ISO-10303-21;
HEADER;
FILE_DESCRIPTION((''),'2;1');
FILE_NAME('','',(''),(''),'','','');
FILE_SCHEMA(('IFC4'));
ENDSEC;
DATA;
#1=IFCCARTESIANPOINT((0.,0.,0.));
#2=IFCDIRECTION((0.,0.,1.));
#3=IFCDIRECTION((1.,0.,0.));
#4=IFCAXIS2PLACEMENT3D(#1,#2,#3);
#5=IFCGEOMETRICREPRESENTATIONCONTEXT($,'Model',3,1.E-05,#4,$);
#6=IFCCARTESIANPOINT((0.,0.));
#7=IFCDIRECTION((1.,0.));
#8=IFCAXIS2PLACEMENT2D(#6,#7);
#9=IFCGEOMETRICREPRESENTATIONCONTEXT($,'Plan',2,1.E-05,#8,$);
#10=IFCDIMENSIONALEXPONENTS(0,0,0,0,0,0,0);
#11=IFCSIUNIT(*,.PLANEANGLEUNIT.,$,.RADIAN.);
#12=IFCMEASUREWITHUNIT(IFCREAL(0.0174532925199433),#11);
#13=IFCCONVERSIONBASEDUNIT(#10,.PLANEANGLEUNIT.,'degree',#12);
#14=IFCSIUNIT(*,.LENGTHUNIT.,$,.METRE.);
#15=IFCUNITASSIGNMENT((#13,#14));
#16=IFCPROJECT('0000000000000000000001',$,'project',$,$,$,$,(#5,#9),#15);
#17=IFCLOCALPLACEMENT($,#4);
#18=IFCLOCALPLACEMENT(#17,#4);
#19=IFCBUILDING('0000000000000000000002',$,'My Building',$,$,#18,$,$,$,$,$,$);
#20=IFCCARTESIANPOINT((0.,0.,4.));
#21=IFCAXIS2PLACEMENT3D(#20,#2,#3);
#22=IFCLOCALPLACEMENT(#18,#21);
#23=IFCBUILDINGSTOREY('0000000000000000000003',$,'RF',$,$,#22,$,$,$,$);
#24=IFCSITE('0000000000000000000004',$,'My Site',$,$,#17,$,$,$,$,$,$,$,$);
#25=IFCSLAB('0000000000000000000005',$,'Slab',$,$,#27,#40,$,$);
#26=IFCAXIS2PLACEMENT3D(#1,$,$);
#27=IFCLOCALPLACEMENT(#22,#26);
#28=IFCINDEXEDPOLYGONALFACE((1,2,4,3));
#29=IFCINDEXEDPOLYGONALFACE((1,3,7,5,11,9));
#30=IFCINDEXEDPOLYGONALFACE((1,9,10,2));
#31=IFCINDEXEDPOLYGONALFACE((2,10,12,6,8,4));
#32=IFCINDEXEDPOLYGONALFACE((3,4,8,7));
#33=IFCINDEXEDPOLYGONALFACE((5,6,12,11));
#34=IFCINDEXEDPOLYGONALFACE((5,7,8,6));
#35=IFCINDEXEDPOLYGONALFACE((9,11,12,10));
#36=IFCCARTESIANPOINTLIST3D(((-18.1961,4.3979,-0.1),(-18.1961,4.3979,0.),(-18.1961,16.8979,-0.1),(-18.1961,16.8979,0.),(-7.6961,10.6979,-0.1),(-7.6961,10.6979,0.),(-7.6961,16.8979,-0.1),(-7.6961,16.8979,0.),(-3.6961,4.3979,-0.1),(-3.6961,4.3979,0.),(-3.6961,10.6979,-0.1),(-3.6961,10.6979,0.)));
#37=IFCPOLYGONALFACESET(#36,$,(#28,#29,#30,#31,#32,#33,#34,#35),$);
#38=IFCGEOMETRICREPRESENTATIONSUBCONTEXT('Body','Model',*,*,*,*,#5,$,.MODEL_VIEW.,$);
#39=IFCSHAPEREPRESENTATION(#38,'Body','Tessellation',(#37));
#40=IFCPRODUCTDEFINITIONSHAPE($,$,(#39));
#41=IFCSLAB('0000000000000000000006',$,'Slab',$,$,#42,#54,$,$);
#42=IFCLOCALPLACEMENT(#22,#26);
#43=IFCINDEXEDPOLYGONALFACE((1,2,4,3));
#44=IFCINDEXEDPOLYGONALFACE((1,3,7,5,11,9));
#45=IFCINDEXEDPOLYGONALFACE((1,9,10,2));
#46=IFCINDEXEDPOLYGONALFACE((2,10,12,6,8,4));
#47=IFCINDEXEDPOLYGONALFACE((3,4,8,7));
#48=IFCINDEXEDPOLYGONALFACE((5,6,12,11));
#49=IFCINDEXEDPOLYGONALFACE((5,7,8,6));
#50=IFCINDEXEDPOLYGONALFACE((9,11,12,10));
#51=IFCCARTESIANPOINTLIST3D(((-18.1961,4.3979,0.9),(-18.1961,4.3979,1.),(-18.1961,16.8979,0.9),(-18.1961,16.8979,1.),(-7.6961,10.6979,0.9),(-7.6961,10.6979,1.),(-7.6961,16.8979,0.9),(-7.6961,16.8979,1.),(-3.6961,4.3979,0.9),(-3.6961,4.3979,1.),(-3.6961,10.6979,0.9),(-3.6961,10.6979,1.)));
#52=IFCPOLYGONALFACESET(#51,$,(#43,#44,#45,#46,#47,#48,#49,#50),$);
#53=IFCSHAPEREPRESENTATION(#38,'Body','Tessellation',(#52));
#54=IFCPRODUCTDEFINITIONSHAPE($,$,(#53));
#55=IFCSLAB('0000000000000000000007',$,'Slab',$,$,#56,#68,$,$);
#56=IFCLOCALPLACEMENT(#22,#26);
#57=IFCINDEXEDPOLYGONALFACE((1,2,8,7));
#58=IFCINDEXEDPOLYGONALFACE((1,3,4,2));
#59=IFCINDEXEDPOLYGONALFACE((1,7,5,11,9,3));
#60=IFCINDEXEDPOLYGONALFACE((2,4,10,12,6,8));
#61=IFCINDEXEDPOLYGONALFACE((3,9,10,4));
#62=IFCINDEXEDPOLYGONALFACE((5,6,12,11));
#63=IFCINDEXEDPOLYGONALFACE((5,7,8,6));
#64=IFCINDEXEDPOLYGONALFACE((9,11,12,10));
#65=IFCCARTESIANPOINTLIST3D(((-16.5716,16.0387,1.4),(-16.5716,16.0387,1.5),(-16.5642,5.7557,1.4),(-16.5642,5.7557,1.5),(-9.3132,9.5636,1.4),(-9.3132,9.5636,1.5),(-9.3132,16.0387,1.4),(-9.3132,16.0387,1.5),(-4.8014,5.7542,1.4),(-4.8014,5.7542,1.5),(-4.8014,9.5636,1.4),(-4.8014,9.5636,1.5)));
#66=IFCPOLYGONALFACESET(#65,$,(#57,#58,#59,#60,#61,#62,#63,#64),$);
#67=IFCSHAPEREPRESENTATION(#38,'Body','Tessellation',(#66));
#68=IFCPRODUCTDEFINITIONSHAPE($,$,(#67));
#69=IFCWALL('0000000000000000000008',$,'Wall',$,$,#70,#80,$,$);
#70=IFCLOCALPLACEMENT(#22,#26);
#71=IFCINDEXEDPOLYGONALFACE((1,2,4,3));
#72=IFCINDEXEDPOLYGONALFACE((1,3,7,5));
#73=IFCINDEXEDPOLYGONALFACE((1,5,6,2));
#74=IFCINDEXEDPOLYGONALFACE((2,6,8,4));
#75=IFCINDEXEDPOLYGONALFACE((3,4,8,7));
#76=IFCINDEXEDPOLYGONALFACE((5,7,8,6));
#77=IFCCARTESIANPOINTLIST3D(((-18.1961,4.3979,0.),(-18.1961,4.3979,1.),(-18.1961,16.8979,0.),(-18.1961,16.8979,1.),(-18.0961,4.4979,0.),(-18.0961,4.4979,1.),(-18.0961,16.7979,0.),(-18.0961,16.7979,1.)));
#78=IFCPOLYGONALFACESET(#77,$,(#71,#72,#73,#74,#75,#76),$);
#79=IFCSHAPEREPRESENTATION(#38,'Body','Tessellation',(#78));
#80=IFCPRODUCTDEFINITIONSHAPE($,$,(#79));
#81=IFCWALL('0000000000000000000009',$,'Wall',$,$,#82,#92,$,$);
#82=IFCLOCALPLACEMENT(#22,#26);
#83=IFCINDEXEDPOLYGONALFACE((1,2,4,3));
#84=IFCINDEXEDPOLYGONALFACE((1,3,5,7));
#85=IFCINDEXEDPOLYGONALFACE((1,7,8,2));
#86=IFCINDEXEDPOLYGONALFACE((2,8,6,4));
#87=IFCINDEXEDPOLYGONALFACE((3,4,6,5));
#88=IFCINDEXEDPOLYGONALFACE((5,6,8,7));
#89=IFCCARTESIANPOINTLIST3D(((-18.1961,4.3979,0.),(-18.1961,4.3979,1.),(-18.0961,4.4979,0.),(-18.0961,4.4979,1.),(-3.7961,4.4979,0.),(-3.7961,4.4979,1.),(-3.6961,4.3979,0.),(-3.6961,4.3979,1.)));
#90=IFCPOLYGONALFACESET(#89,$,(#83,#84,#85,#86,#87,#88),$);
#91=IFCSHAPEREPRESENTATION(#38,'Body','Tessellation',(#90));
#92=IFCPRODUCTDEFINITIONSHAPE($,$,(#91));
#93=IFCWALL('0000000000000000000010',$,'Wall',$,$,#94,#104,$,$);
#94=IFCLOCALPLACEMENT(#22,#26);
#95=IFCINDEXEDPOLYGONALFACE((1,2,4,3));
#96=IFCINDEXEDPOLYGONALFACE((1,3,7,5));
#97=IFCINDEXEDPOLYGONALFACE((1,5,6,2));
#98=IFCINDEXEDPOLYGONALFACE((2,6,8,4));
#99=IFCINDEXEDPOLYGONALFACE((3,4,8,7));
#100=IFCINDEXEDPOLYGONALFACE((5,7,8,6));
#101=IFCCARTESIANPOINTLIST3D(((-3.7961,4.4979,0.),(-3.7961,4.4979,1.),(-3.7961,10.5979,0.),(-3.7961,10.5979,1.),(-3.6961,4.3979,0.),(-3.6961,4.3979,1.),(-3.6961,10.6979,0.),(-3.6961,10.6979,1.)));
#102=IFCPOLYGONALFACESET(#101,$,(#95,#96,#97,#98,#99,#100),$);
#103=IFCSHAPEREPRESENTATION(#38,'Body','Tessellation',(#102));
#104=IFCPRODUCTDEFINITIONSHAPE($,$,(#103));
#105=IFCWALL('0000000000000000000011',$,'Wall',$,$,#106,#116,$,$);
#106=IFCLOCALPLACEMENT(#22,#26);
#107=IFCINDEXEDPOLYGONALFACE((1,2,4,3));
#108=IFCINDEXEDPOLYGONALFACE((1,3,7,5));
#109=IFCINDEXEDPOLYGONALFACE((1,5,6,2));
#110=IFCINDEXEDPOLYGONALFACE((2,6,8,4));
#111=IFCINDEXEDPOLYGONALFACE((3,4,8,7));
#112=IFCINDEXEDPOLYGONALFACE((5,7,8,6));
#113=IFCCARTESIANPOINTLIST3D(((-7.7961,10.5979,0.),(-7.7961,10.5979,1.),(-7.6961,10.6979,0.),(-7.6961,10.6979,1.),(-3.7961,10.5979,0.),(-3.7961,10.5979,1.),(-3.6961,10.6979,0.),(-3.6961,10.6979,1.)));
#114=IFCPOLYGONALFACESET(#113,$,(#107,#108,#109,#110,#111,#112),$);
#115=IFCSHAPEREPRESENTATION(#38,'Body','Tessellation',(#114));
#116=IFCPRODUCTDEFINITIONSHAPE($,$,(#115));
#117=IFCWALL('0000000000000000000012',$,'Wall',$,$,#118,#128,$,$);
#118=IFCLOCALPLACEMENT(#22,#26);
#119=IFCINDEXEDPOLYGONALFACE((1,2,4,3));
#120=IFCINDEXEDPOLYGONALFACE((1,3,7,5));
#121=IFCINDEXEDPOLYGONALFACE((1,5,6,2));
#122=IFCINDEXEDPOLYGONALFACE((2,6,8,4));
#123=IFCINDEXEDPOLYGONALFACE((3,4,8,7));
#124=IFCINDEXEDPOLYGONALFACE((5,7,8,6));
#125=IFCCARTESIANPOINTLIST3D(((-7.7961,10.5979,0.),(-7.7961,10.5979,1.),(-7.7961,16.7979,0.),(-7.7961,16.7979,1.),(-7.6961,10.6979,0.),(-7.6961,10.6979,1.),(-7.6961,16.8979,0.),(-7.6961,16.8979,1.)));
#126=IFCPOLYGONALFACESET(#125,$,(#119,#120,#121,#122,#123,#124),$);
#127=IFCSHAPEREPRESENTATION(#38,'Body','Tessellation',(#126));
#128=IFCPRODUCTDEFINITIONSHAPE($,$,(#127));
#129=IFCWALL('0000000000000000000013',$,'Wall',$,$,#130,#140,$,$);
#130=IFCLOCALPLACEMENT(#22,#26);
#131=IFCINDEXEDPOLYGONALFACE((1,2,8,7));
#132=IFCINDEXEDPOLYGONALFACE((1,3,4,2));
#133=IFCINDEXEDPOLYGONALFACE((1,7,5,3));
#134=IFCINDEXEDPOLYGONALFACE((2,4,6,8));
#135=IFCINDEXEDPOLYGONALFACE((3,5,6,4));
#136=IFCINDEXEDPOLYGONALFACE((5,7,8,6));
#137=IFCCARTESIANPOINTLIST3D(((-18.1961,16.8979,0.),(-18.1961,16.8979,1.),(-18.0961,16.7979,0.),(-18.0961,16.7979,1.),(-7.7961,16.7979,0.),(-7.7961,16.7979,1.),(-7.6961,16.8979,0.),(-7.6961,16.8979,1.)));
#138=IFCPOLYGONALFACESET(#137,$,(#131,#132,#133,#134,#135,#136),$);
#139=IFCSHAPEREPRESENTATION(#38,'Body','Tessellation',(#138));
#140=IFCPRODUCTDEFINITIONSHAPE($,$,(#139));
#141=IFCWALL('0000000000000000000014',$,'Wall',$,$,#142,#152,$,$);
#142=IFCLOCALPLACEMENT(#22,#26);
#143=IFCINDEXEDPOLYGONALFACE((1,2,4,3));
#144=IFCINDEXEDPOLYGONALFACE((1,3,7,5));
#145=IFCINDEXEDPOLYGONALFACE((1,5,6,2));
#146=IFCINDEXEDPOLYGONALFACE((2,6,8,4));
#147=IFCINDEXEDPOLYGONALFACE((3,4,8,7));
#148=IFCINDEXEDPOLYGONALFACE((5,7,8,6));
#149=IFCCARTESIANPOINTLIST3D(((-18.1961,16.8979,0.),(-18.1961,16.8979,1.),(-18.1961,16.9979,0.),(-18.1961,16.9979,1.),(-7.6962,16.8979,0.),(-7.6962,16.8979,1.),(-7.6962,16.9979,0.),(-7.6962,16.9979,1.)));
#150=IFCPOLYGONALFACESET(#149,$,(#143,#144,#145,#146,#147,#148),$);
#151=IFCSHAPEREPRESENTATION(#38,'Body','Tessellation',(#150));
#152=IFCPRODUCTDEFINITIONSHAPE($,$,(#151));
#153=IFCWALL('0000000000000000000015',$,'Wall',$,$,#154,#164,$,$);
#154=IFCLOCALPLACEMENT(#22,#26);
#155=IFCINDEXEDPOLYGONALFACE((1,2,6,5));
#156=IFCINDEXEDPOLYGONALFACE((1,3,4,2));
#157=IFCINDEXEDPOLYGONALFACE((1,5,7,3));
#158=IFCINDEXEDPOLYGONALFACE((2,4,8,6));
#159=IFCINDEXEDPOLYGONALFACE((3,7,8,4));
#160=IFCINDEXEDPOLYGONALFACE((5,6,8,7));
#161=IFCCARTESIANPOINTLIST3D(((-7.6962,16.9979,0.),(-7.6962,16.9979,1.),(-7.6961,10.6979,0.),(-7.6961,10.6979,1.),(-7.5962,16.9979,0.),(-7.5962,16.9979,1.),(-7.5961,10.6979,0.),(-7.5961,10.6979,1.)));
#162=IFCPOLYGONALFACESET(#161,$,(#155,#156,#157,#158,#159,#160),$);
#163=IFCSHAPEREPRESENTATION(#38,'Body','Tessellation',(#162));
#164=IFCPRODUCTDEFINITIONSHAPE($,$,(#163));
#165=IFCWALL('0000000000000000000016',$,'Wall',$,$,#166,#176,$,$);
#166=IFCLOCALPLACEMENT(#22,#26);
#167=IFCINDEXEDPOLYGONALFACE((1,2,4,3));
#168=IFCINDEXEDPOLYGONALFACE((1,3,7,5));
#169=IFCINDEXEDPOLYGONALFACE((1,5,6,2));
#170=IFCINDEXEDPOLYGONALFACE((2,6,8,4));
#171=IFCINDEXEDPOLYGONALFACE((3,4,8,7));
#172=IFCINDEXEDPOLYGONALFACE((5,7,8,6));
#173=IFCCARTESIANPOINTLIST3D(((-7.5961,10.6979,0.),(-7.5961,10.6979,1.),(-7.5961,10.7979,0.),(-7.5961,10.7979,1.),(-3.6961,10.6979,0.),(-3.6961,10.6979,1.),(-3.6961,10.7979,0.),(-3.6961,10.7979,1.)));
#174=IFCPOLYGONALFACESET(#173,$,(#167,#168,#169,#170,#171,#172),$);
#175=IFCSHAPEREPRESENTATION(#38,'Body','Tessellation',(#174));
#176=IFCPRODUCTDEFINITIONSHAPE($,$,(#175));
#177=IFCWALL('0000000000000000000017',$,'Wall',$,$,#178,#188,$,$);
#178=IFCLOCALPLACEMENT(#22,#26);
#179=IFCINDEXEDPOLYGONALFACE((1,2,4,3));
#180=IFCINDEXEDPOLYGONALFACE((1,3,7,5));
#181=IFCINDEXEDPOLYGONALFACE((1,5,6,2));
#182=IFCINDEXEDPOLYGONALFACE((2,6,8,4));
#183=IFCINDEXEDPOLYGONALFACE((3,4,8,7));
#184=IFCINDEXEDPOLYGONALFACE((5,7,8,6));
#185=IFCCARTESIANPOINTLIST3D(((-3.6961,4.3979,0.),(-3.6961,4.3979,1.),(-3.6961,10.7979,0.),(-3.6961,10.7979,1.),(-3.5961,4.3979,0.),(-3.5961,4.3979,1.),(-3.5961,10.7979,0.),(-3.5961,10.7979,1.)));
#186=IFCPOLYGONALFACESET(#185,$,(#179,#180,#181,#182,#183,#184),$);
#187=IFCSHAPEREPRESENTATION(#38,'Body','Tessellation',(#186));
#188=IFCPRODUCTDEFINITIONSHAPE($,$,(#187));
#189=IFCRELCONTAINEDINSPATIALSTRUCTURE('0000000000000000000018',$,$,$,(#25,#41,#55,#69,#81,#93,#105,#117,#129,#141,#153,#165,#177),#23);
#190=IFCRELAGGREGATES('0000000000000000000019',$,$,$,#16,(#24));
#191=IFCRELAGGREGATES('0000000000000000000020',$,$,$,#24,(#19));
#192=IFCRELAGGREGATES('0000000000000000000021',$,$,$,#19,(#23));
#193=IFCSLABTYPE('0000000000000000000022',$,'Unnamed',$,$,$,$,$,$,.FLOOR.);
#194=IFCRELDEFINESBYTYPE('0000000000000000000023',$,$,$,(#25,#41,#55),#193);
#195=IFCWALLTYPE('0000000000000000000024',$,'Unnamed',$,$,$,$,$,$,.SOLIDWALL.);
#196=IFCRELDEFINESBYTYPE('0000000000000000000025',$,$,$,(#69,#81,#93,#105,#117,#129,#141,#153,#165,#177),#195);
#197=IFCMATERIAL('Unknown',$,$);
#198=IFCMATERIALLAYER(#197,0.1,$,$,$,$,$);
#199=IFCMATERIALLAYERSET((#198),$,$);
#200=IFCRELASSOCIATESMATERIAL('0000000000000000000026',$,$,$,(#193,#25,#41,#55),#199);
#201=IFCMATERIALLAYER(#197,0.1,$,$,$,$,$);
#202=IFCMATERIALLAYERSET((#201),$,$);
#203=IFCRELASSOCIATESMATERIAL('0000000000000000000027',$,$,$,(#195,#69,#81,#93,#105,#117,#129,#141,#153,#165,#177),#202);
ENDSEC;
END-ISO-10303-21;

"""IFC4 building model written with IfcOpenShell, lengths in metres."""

from ifc_helpers import new_model, entity, si_unit, converted_unit, frame, origin_with_axes, origin_2d_with_axis, place, context, subcontext, project, spatial, line, indexed_curve, outline, extrude, material, layer, layer_set, layer_usage, type_object, element, save


model = new_model("IFC4")

# Units and contexts
model_context = context("Model", 3, precision=1e-05, world=origin_with_axes())
plan_context = context("Plan", 2, precision=1e-05, world=origin_2d_with_axis())
body_context = subcontext(model_context, "Body", "Model", "MODEL_VIEW")
ifc_project = project(units=[converted_unit("PLANEANGLEUNIT", "degree", entity("IfcReal", 0.0174532925199433), si_unit("PLANEANGLEUNIT", "RADIAN"), dimensions=[0, 0, 0, 0, 0, 0, 0]), si_unit("LENGTHUNIT", "METRE")], contexts=[model_context, plan_context])

# Site, building, storey
site_placement = place(None, origin_with_axes())
site = spatial("IfcSite", under=ifc_project, at=site_placement, Name="My Site")
building_placement = place(site_placement, origin_with_axes())
building = spatial("IfcBuilding", under=site, at=building_placement, Name="My Building")
storey_placement = place(building_placement, frame((0.0, 0.0, 4.0), z_axis=(0.0, 0.0, 1.0), x_axis=(1.0, 0.0, 0.0)))
storey = spatial("IfcBuildingStorey", under=building, at=storey_placement, Name="RF")

# Slabs
ifc_material = material(Name="Unknown")
ifc_layer_1 = layer(ifc_material, 0.1)
ifc_layer_set_1 = layer_set([ifc_layer_1])
ifc_layer_usage_1 = layer_usage(ifc_layer_set_1, "AXIS3", "POSITIVE", -0.1)
slab_type = type_object("IfcSlabType", Name="Unnamed", PredefinedType="FLOOR", material=ifc_layer_set_1)
slab_1_placement = place(storey_placement, frame((-18.1961, 16.8979, 0.0), z_axis=(0.0, 0.0, 1.0), x_axis=(1.0, 0.0, 0.0)))
element("IfcSlab", 1, at=slab_1_placement, inside=storey, type_object=slab_type, material=ifc_layer_usage_1, Name="Slab", context=body_context, shape_type="SweptSolid", body=[
    extrude(outline(indexed_curve([(0.0, 0.0), (10.5, 0.0), (10.5, -6.2), (14.5, -6.2), (14.5, -12.5), (0.0, -12.5), (0.0, 0.0)])), frame((0.0, 0.0, -0.1), z_axis=(0.0, 0.0, 1.0), x_axis=(1.0, 0.0, 0.0)), (0.0, 0.0, 1.0), 0.1),
])
ifc_layer_usage_2 = layer_usage(ifc_layer_set_1, "AXIS3", "POSITIVE", -0.1)
slab_2_placement = place(storey_placement, frame((-18.1961, 16.8979, 1.0), z_axis=(0.0, 0.0, 1.0), x_axis=(1.0, 0.0, 0.0)))
element("IfcSlab", 2, at=slab_2_placement, inside=storey, type_object=slab_type, material=ifc_layer_usage_2, Name="Slab", context=body_context, shape_type="SweptSolid", body=[
    extrude(outline(indexed_curve([(0.0, 0.0), (10.5, 0.0), (10.5, -6.2), (14.5, -6.2), (14.5, -12.5), (0.0, -12.5), (0.0, 0.0)])), frame((0.0, 0.0, -0.1), z_axis=(0.0, 0.0, 1.0), x_axis=(1.0, 0.0, 0.0)), (0.0, 0.0, 1.0), 0.1),
])
ifc_layer_usage_3 = layer_usage(ifc_layer_set_1, "AXIS3", "POSITIVE", -0.1)
slab_3_placement = place(storey_placement, frame((-16.5716, 16.0387, 1.5), z_axis=(0.0, 0.0, 1.0), x_axis=(1.0, 0.0, 0.0)))
element("IfcSlab", 3, at=slab_3_placement, inside=storey, type_object=slab_type, material=ifc_layer_usage_3, Name="Slab", context=body_context, shape_type="SweptSolid", body=[
    extrude(outline(indexed_curve([(0.0, 0.0), (7.2584, 0.0), (7.2584, -6.4751), (11.7702, -6.4751), (11.7702, -10.2844), (0.0074, -10.283), (0.0, 0.0)])), frame((0.0, 0.0, -0.1), z_axis=(0.0, 0.0, 1.0), x_axis=(1.0, 0.0, 0.0)), (0.0, 0.0, 1.0), 0.1),
])

# Walls
ifc_layer_2 = layer(ifc_material, 0.1)
ifc_layer_set_2 = layer_set([ifc_layer_2])
ifc_layer_usage_4 = layer_usage(ifc_layer_set_2, "AXIS2", "POSITIVE", 0.0)
wall_type = type_object("IfcWallType", Name="Unnamed", PredefinedType="SOLIDWALL", material=ifc_layer_set_2)
wall_1_placement = place(storey_placement, frame((-18.1961, 16.8979, 0.0), z_axis=(0.0, 0.0, 1.0), x_axis=(0.0, -1.0, 0.0)))
element("IfcWall", 4, at=wall_1_placement, inside=storey, type_object=wall_type, material=ifc_layer_usage_4, Name="Wall", context=body_context, shape_type="SweptSolid", body=[
    extrude(outline(indexed_curve([(0.0, 0.0), (0.1, 0.1), (12.4, 0.1), (12.5, 0.0)], segments=[line(1, 2, 3, 4, 1)])), origin_with_axes(), (0.0, 0.0, 1.0), 1.0),
])
ifc_layer_usage_5 = layer_usage(ifc_layer_set_2, "AXIS2", "POSITIVE", 0.0)
wall_2_placement = place(storey_placement, frame((-18.1961, 4.3979, 0.0), z_axis=(0.0, 0.0, 1.0), x_axis=(1.0, 0.0, 0.0)))
element("IfcWall", 5, at=wall_2_placement, inside=storey, type_object=wall_type, material=ifc_layer_usage_5, Name="Wall", context=body_context, shape_type="SweptSolid", body=[
    extrude(outline(indexed_curve([(0.0, 0.0), (0.1, 0.1), (14.4, 0.1), (14.5, 0.0)], segments=[line(1, 2, 3, 4, 1)])), origin_with_axes(), (0.0, 0.0, 1.0), 1.0),
])
ifc_layer_usage_6 = layer_usage(ifc_layer_set_2, "AXIS2", "POSITIVE", 0.0)
wall_3_placement = place(storey_placement, frame((-3.6961, 4.3979, 0.0), z_axis=(0.0, 0.0, 1.0), x_axis=(0.0, 1.0, 0.0)))
element("IfcWall", 6, at=wall_3_placement, inside=storey, type_object=wall_type, material=ifc_layer_usage_6, Name="Wall", context=body_context, shape_type="SweptSolid", body=[
    extrude(outline(indexed_curve([(0.0, 0.0), (0.1, 0.1), (6.2, 0.1), (6.3, 0.0)], segments=[line(1, 2, 3, 4, 1)])), origin_with_axes(), (0.0, 0.0, 1.0), 1.0),
])
ifc_layer_usage_7 = layer_usage(ifc_layer_set_2, "AXIS2", "POSITIVE", 0.0)
wall_4_placement = place(storey_placement, frame((-3.6961, 10.6979, 0.0), z_axis=(0.0, 0.0, 1.0), x_axis=(-1.0, 0.0, 0.0)))
element("IfcWall", 7, at=wall_4_placement, inside=storey, type_object=wall_type, material=ifc_layer_usage_7, Name="Wall", context=body_context, shape_type="SweptSolid", body=[
    extrude(outline(indexed_curve([(0.0, 0.0), (0.1, 0.1), (4.1, 0.1), (4.0, 0.0)], segments=[line(1, 2, 3, 4, 1)])), origin_with_axes(), (0.0, 0.0, 1.0), 1.0),
])
ifc_layer_usage_8 = layer_usage(ifc_layer_set_2, "AXIS2", "POSITIVE", 0.0)
wall_5_placement = place(storey_placement, frame((-7.6961, 10.6979, 0.0), z_axis=(0.0, 0.0, 1.0), x_axis=(0.0, 1.0, 0.0)))
element("IfcWall", 8, at=wall_5_placement, inside=storey, type_object=wall_type, material=ifc_layer_usage_8, Name="Wall", context=body_context, shape_type="SweptSolid", body=[
    extrude(outline(indexed_curve([(0.0, 0.0), (-0.1, 0.1), (6.1, 0.1), (6.2, 0.0)], segments=[line(1, 2, 3, 4, 1)])), origin_with_axes(), (0.0, 0.0, 1.0), 1.0),
])
ifc_layer_usage_9 = layer_usage(ifc_layer_set_2, "AXIS2", "POSITIVE", 0.0)
wall_6_placement = place(storey_placement, frame((-7.6961, 16.8979, 0.0), z_axis=(0.0, 0.0, 1.0), x_axis=(-1.0, 0.0, 0.0)))
element("IfcWall", 9, at=wall_6_placement, inside=storey, type_object=wall_type, material=ifc_layer_usage_9, Name="Wall", context=body_context, shape_type="SweptSolid", body=[
    extrude(outline(indexed_curve([(0.0, 0.0), (0.1, 0.1), (10.4, 0.1), (10.5, 0.0)], segments=[line(1, 2, 3, 4, 1)])), origin_with_axes(), (0.0, 0.0, 1.0), 1.0),
])
ifc_layer_usage_10 = layer_usage(ifc_layer_set_2, "AXIS2", "POSITIVE", 0.0)
wall_7_placement = place(storey_placement, frame((-18.1961, 16.8979, 0.0), z_axis=(0.0, 0.0, 1.0), x_axis=(1.0, 0.0, 0.0)))
element("IfcWall", 10, at=wall_7_placement, inside=storey, type_object=wall_type, material=ifc_layer_usage_10, Name="Wall", context=body_context, shape_type="SweptSolid", body=[
    extrude(outline(indexed_curve([(0.0, 0.0), (0.0, 0.1), (10.4999, 0.1), (10.4999, 0.0)], segments=[line(1, 2, 3, 4, 1)])), origin_with_axes(), (0.0, 0.0, 1.0), 1.0),
])
ifc_layer_usage_11 = layer_usage(ifc_layer_set_2, "AXIS2", "POSITIVE", 0.0)
wall_8_placement = place(storey_placement, frame((-7.6962, 16.9979, 0.0), z_axis=(0.0, 0.0, 1.0), x_axis=(0.000012, -1.0, 0.0)))
element("IfcWall", 11, at=wall_8_placement, inside=storey, type_object=wall_type, material=ifc_layer_usage_11, Name="Wall", context=body_context, shape_type="SweptSolid", body=[
    extrude(outline(indexed_curve([(0.0, 0.0), (0.0, 0.1), (6.3, 0.1), (6.3, 0.0)], segments=[line(1, 2, 3, 4, 1)])), origin_with_axes(), (0.0, 0.0, 1.0), 1.0),
])
ifc_layer_usage_12 = layer_usage(ifc_layer_set_2, "AXIS2", "POSITIVE", 0.0)
wall_9_placement = place(storey_placement, frame((-7.5961, 10.6979, 0.0), z_axis=(0.0, 0.0, 1.0), x_axis=(1.0, 0.0, 0.0)))
element("IfcWall", 12, at=wall_9_placement, inside=storey, type_object=wall_type, material=ifc_layer_usage_12, Name="Wall", context=body_context, shape_type="SweptSolid", body=[
    extrude(outline(indexed_curve([(0.0, 0.0), (0.0, 0.1), (3.9, 0.1), (3.9, 0.0)], segments=[line(1, 2, 3, 4, 1)])), origin_with_axes(), (0.0, 0.0, 1.0), 1.0),
])
ifc_layer_usage_13 = layer_usage(ifc_layer_set_2, "AXIS2", "POSITIVE", 0.0)
wall_10_placement = place(storey_placement, frame((-3.6961, 10.7979, 0.0), z_axis=(0.0, 0.0, 1.0), x_axis=(0.0, -1.0, 0.0)))
element("IfcWall", 13, at=wall_10_placement, inside=storey, type_object=wall_type, material=ifc_layer_usage_13, Name="Wall", context=body_context, shape_type="SweptSolid", body=[
    extrude(outline(indexed_curve([(0.0, 0.0), (0.0, 0.1), (6.4, 0.1), (6.4, 0.0)], segments=[line(1, 2, 3, 4, 1)])), origin_with_axes(), (0.0, 0.0, 1.0), 1.0),
])

save(model, "model.ifc")
